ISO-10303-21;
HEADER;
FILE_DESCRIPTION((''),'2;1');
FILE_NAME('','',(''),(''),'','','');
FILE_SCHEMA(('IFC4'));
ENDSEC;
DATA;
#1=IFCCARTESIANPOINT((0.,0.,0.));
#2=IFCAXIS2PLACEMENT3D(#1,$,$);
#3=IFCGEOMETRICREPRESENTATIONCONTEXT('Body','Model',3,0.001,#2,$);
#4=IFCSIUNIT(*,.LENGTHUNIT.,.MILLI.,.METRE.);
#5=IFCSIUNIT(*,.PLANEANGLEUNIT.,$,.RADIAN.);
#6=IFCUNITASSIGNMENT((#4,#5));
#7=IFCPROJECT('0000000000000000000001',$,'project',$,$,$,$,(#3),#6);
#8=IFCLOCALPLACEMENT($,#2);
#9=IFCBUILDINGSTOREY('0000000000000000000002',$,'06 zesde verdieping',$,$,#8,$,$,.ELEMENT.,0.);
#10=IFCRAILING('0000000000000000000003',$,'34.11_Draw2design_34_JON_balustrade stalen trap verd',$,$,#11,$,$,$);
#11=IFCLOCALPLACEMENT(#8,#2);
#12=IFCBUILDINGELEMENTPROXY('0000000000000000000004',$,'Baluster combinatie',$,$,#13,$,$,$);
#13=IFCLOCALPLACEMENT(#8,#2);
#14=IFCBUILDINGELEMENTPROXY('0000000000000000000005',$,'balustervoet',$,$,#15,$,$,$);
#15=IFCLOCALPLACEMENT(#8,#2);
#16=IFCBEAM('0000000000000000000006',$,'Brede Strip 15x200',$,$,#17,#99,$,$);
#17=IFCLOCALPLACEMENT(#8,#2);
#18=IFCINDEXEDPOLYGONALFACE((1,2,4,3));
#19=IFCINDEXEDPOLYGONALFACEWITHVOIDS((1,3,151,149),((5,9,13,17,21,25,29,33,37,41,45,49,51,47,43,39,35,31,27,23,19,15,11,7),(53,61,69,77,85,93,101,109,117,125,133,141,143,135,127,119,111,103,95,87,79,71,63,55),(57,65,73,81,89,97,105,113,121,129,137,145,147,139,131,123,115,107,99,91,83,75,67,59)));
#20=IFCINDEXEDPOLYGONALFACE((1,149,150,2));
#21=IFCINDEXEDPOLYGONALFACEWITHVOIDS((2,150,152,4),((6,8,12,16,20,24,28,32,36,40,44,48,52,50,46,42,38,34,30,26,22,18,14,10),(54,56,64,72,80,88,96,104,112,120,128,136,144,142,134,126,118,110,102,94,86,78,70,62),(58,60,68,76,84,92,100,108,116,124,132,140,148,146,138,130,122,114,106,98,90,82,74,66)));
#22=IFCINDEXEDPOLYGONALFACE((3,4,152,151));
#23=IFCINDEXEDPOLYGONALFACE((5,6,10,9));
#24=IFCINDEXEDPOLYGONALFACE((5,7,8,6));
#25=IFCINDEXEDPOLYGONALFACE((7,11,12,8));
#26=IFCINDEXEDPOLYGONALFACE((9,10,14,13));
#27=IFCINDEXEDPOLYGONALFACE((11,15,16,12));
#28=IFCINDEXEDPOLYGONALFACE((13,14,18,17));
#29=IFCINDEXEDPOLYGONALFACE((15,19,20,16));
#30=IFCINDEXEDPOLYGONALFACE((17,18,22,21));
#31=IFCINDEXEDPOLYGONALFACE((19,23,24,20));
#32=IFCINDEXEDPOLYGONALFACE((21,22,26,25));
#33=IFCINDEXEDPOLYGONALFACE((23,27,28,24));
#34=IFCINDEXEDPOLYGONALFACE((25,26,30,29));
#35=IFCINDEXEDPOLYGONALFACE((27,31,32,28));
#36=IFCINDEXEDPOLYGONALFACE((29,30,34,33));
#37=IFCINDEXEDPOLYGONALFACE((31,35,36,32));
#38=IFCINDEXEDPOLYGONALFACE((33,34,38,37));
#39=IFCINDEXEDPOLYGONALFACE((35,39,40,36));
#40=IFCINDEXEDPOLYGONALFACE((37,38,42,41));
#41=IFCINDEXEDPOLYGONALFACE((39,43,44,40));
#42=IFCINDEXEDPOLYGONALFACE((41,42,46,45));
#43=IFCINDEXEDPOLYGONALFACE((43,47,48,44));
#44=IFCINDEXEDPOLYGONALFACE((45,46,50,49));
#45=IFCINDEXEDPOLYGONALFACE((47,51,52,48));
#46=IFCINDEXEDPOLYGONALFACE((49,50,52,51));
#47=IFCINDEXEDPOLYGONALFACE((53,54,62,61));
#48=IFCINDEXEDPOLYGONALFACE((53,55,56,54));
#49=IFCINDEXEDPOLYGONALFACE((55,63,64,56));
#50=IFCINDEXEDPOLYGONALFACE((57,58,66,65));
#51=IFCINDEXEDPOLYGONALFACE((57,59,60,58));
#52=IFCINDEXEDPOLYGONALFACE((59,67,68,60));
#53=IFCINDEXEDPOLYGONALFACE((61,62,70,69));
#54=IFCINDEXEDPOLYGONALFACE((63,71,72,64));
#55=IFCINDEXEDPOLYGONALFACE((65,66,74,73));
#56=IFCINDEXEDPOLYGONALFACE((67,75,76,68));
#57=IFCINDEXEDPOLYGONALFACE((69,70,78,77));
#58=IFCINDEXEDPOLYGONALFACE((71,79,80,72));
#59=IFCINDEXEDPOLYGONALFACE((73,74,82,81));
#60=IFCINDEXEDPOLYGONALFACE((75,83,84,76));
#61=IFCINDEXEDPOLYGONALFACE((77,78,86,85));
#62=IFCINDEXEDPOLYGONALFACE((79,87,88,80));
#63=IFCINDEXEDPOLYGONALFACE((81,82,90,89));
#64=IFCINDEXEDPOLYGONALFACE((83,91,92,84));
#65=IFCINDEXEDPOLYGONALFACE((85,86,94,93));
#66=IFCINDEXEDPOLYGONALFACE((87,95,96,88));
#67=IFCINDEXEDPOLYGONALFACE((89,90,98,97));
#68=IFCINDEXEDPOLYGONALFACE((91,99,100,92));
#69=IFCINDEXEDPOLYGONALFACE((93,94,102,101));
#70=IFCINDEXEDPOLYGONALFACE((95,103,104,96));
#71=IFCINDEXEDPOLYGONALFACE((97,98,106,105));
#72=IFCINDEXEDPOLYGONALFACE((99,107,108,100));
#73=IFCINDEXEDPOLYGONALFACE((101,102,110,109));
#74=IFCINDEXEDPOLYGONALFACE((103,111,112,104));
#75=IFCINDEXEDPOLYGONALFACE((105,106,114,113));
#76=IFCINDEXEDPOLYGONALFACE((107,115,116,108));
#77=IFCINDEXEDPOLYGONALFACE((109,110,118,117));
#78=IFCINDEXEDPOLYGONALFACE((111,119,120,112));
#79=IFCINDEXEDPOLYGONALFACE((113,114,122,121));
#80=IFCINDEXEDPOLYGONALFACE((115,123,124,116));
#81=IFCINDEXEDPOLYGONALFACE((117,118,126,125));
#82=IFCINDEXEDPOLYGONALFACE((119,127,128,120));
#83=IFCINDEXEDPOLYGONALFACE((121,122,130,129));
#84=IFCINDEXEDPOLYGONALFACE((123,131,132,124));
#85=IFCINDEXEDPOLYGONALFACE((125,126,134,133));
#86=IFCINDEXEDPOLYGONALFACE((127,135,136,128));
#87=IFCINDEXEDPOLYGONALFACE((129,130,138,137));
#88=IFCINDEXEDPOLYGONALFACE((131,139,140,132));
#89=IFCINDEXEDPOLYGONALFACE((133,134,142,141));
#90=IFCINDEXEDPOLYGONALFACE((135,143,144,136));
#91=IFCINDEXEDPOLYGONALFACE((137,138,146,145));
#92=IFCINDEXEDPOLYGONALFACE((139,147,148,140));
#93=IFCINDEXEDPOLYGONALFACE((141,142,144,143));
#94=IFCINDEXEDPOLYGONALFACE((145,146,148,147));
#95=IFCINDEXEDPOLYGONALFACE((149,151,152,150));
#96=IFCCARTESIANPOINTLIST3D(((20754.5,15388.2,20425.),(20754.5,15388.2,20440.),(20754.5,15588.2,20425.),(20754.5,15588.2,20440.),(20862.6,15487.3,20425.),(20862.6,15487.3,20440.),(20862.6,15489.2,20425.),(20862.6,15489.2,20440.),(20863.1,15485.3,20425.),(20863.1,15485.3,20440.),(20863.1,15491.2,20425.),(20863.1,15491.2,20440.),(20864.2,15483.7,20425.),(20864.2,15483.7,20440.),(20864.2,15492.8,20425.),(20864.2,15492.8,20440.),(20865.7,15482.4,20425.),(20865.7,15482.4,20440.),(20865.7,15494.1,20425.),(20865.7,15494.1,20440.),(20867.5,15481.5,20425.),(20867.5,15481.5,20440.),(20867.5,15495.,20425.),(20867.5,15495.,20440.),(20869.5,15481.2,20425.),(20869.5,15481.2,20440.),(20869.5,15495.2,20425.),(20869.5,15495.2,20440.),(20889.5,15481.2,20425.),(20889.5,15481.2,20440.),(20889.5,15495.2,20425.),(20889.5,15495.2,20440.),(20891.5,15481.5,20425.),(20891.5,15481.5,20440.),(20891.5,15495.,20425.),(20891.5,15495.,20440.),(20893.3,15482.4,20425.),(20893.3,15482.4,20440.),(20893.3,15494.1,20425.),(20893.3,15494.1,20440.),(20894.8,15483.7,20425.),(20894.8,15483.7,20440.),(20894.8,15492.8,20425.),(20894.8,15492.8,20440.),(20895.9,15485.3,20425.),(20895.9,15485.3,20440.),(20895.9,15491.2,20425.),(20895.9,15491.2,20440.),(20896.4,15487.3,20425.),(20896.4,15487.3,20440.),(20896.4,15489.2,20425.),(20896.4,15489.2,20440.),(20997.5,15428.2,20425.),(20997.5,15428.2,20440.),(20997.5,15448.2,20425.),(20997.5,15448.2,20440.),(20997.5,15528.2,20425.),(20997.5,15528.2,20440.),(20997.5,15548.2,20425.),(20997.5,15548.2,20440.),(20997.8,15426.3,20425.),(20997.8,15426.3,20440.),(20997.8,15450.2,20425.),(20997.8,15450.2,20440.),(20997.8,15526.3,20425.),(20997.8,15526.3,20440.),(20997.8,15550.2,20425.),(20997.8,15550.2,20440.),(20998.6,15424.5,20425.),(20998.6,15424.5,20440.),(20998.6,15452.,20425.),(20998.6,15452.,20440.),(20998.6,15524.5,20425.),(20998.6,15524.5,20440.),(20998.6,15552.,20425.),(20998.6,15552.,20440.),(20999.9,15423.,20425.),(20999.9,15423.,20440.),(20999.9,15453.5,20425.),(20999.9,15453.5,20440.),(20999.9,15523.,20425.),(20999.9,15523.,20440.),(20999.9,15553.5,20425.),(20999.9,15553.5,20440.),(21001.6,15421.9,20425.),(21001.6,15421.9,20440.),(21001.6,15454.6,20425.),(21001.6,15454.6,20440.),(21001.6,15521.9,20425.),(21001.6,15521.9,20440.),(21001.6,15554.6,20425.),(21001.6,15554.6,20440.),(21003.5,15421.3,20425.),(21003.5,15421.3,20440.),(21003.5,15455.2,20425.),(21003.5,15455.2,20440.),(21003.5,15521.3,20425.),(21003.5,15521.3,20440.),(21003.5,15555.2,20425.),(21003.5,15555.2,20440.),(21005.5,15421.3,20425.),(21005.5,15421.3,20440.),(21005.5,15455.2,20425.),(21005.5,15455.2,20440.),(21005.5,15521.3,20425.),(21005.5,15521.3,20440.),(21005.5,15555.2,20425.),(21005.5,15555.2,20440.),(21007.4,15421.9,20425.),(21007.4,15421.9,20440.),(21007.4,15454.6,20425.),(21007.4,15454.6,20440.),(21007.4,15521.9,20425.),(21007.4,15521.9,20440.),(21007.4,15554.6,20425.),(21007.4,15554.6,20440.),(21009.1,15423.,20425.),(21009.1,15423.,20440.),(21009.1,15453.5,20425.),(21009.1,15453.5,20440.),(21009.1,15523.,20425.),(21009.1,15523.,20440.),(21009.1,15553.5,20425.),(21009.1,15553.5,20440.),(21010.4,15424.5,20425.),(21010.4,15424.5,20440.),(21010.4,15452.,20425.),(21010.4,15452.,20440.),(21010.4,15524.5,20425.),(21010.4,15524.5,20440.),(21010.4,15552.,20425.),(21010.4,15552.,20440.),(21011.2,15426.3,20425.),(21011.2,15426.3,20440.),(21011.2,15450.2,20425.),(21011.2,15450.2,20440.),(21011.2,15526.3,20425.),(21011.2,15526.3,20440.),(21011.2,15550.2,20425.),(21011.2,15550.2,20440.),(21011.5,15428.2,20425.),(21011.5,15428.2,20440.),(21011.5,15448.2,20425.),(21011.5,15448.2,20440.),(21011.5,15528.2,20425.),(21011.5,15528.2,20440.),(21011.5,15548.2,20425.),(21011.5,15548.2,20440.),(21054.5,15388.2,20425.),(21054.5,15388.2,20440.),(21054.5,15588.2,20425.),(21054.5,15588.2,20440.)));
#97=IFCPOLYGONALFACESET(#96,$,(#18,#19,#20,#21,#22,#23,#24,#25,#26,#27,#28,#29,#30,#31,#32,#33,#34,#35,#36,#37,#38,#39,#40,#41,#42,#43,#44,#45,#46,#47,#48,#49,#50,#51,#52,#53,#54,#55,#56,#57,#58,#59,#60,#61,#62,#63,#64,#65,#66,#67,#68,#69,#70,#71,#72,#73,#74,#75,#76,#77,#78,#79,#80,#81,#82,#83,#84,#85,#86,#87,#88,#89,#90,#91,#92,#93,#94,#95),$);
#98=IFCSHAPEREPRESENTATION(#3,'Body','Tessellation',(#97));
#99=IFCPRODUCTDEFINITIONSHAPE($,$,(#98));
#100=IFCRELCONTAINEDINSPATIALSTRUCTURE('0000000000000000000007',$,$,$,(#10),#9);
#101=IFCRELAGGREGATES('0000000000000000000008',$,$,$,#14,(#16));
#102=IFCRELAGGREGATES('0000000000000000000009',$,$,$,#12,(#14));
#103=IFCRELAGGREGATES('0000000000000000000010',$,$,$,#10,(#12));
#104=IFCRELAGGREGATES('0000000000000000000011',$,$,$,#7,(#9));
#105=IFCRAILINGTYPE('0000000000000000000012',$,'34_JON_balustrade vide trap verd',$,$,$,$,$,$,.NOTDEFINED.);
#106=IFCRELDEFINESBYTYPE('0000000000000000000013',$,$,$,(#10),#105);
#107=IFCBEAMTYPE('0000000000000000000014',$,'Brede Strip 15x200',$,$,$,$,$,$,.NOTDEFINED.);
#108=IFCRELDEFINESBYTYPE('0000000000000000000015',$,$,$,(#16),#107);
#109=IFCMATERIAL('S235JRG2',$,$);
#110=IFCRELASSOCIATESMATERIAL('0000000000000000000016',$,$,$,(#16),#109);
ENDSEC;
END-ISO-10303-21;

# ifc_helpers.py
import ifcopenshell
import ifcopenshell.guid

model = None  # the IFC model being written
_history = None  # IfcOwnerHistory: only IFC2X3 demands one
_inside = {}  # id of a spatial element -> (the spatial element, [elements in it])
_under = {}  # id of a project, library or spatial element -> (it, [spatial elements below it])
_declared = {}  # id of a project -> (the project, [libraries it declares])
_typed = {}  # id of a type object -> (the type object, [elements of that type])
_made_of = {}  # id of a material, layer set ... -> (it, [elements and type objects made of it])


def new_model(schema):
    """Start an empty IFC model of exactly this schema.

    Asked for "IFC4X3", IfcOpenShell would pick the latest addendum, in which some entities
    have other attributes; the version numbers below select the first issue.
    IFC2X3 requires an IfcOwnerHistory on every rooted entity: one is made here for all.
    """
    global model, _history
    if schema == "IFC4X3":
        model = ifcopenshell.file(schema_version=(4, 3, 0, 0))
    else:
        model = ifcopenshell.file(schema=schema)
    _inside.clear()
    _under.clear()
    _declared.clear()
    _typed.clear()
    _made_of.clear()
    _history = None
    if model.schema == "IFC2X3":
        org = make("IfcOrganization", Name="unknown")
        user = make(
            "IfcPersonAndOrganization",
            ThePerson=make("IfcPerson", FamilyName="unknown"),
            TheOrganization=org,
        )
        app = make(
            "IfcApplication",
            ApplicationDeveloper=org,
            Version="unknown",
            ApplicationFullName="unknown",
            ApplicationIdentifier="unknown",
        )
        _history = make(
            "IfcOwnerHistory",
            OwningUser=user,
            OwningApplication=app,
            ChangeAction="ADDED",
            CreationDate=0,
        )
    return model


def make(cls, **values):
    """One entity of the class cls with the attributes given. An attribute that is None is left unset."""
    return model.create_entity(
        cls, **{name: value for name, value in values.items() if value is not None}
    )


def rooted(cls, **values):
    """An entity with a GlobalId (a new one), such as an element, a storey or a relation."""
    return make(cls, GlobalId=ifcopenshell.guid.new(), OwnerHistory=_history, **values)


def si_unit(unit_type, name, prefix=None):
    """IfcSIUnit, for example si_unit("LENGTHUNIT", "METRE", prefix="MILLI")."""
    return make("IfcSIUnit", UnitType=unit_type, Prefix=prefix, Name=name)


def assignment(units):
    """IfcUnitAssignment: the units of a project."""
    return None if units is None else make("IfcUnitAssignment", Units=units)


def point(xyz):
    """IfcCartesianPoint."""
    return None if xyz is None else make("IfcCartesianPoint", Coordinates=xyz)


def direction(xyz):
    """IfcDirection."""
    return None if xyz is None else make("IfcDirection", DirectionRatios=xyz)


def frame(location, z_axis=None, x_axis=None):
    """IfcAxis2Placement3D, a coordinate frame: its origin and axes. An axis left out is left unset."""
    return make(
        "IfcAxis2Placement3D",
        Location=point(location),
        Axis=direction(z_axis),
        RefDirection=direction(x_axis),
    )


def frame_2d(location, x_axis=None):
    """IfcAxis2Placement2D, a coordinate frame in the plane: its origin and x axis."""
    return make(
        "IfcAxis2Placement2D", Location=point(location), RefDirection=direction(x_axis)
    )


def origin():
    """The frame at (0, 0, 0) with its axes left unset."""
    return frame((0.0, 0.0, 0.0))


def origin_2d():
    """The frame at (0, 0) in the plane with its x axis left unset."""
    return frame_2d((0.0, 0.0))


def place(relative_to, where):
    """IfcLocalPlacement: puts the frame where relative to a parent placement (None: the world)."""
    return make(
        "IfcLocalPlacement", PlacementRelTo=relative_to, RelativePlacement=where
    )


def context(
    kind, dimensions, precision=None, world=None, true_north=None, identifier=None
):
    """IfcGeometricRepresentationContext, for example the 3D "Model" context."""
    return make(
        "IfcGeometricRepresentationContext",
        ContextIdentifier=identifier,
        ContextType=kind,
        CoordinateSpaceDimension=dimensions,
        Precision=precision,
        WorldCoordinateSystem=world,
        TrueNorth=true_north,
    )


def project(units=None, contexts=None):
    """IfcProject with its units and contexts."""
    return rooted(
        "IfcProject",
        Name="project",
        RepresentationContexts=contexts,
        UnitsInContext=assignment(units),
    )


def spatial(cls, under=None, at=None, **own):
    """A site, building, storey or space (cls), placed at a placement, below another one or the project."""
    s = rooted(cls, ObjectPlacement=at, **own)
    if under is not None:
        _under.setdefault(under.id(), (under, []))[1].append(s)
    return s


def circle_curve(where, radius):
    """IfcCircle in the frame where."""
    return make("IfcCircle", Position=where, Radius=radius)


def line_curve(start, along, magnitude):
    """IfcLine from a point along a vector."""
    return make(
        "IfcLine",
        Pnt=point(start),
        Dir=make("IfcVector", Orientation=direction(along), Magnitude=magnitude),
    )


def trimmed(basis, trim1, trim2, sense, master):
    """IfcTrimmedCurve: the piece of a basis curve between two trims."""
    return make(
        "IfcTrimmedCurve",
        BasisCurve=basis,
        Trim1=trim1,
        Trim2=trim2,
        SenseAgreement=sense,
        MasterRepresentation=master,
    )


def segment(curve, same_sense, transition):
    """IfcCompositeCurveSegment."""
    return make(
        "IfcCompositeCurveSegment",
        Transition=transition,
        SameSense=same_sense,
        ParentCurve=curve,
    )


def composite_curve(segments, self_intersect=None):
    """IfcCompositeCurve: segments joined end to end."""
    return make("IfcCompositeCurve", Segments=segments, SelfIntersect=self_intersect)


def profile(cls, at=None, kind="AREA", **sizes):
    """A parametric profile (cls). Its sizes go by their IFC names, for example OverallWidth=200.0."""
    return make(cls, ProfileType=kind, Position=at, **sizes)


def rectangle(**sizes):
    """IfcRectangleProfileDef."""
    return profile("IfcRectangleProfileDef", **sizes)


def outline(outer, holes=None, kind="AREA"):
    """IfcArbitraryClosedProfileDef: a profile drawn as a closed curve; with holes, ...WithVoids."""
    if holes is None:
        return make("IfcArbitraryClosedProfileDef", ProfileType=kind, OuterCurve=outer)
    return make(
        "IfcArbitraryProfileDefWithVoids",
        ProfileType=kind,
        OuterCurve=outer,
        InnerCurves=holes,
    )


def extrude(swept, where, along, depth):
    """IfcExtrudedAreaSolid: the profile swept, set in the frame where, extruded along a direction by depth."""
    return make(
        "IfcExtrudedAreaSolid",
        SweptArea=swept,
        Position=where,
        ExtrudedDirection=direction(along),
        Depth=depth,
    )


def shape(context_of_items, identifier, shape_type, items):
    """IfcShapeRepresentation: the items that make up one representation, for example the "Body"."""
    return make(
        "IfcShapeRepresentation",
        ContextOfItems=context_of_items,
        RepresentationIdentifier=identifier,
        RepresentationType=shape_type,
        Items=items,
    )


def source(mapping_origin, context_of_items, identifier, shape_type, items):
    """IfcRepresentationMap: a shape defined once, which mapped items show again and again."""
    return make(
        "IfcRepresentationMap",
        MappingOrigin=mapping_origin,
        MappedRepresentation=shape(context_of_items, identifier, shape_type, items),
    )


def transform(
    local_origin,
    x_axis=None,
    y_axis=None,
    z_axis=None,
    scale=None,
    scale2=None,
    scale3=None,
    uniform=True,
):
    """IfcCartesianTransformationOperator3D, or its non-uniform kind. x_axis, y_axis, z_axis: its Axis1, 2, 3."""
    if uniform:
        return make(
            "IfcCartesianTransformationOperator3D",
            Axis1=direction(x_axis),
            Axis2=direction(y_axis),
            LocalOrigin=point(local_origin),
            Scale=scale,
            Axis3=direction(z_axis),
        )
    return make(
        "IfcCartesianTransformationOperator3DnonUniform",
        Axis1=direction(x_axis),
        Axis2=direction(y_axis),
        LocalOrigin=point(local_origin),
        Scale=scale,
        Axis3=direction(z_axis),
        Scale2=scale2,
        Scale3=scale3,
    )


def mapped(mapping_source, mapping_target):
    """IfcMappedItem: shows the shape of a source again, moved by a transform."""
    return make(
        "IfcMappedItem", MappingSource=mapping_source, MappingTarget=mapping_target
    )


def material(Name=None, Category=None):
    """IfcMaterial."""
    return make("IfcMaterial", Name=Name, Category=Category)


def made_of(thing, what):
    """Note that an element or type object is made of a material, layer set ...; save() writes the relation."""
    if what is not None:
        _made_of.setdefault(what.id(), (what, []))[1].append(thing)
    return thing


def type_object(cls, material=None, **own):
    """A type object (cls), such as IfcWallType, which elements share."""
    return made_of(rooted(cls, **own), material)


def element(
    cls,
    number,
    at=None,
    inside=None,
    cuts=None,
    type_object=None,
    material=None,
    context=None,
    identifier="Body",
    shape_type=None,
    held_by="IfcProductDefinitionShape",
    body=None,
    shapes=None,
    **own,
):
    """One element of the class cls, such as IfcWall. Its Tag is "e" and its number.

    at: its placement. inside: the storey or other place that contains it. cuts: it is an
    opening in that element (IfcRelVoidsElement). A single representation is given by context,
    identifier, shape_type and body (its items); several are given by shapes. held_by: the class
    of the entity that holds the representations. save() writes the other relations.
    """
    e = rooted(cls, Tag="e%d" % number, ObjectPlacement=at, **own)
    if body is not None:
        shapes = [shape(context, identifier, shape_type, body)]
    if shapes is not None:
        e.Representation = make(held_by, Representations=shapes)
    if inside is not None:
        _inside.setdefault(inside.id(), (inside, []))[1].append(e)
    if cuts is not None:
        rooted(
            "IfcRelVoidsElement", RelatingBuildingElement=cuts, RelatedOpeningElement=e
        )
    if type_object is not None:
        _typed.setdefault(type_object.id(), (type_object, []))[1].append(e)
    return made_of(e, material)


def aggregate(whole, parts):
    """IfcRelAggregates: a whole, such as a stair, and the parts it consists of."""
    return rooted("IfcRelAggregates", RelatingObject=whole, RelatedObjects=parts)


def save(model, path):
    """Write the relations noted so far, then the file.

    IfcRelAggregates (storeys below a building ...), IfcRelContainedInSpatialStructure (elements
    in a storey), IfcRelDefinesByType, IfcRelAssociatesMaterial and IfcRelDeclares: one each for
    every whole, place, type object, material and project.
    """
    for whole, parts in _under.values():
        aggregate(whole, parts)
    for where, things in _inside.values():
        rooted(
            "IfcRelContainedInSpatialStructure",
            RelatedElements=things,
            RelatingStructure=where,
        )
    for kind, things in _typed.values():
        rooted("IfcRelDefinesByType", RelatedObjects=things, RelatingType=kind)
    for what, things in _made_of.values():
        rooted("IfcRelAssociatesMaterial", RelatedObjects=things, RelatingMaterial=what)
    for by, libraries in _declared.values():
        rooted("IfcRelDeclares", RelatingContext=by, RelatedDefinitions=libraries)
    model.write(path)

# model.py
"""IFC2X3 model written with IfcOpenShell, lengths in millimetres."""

from ifc_helpers import new_model, si_unit, point, frame, frame_2d, origin, origin_2d, place, context, project, spatial, circle_curve, line_curve, trimmed, segment, composite_curve, rectangle, outline, extrude, source, transform, mapped, material, type_object, element, aggregate, save


model = new_model("IFC2X3")

# Units and contexts
model_context = context("Model", 3, precision=0.001, world=origin(), identifier="Body")
ifc_project = project(units=[si_unit("LENGTHUNIT", "METRE", prefix="MILLI"), si_unit("PLANEANGLEUNIT", "RADIAN")], contexts=[model_context])

# Storey
storey_placement = place(None, origin())
storey = spatial("IfcBuildingStorey", under=ifc_project, at=storey_placement, Name="06 zesde verdieping", CompositionType="ELEMENT", Elevation=0.0)

# Railing, building element proxies, beam, openings
railing_type = type_object("IfcRailingType", Name="34_JON_balustrade vide trap verd")
railing_placement = place(storey_placement, frame((-1939.6, -29817.1, 74783.6)))
railing = element("IfcRailing", 1, at=railing_placement, inside=storey, type_object=railing_type, Name="34.11_Draw2design_34_JON_balustrade stalen trap verd")
proxy_1_placement = place(railing_placement, frame((22994.2, 44650.4, -54348.6), z_axis=(0.0, 0.0, 1.0), x_axis=(0.0, 1.0, 0.0)))
proxy_1 = element("IfcBuildingElementProxy", 2, at=proxy_1_placement, Name="Baluster combinatie")
proxy_2_placement = place(proxy_1_placement, frame((-44257.5, 21054.5, -49235.0), z_axis=(0.0, 0.0, 1.0), x_axis=(0.0, -1.0, 0.0)))
proxy_2 = element("IfcBuildingElementProxy", 3, at=proxy_2_placement, Name="balustervoet")
ifc_material_1 = material(Name="S235JRG2")
beam_type_1 = type_object("IfcBeamType", Name="Brede Strip 15x200")
shared_shape_1 = source(origin(), model_context, "Body", "SweptSolid", [
    extrude(rectangle(XDim=15.0, YDim=200.0, at=origin_2d()), origin(), (0.0, 0.0, -1.0), 300.0),
])
beam_1_placement = place(proxy_2_placement, frame((21054.5, 44912.5, 49232.5), z_axis=(1.0, 0.0, 0.0), x_axis=(0.0, 0.0, 1.0)))
beam_1 = element("IfcBeam", 4, at=beam_1_placement, type_object=beam_type_1, material=ifc_material_1, Name="Brede Strip 15x200", context=model_context, shape_type="MappedRepresentation", body=[
    mapped(shared_shape_1, transform((0.0, 0.0, 0.0), scale=1.0)),
])
opening_1_placement = place(beam_1_placement, frame((7.5, 0.0, -175.0), z_axis=(-1.0, 0.0, 0.0), x_axis=(0.0, 0.0, -1.0)))
element("IfcOpeningElement", 5, at=opening_1_placement, cuts=beam_1, ObjectType="Opening", context=model_context, shape_type="SweptSolid", body=[
    extrude(outline(composite_curve([segment(trimmed(circle_curve(frame_2d((10.0, 0.0), x_axis=(0.0, -1.0)), 7.0), [point((10.0, 7.0))], [point((10.0, -7.0))], False, "CARTESIAN"), True, "CONTINUOUS"), segment(trimmed(line_curve((10.0, -7.0), (-20.0, 0.0), 20.0), [point((10.0, -7.0))], [point((-10.0, -7.0))], True, "CARTESIAN"), True, "CONTINUOUS"), segment(trimmed(circle_curve(frame_2d((-10.0, 0.0), x_axis=(0.0, -1.0)), 7.0), [point((-10.0, -7.0))], [point((-10.0, 7.0))], False, "CARTESIAN"), True, "CONTINUOUS"), segment(trimmed(line_curve((-10.0, 7.0), (20.0, 0.0), 20.0), [point((-10.0, 7.0))], [point((10.0, 7.0))], True, "CARTESIAN"), True, "CONTINUOUS")], self_intersect=False)), origin(), (0.0, 0.0, 1.0), 15.0),
])
opening_2_placement = place(beam_1_placement, frame((7.5, -50.0, -50.0), z_axis=(-1.0, 0.0, 0.0), x_axis=(0.0, -1.0, 0.0)))
element("IfcOpeningElement", 6, at=opening_2_placement, cuts=beam_1, ObjectType="Opening", context=model_context, shape_type="SweptSolid", body=[
    extrude(outline(composite_curve([segment(trimmed(circle_curve(frame_2d((10.0, 0.0), x_axis=(0.0, -1.0)), 7.0), [point((10.0, 7.0))], [point((10.0, -7.0))], False, "CARTESIAN"), True, "CONTINUOUS"), segment(trimmed(line_curve((10.0, -7.0), (-20.0, 0.0), 20.0), [point((10.0, -7.0))], [point((-10.0, -7.0))], True, "CARTESIAN"), True, "CONTINUOUS"), segment(trimmed(circle_curve(frame_2d((-10.0, 0.0), x_axis=(0.0, -1.0)), 7.0), [point((-10.0, -7.0))], [point((-10.0, 7.0))], False, "CARTESIAN"), True, "CONTINUOUS"), segment(trimmed(line_curve((-10.0, 7.0), (20.0, 0.0), 20.0), [point((-10.0, 7.0))], [point((10.0, 7.0))], True, "CARTESIAN"), True, "CONTINUOUS")], self_intersect=False)), origin(), (0.0, 0.0, 1.0), 15.0),
])
opening_3_placement = place(beam_1_placement, frame((7.5, 50.0, -50.0), z_axis=(-1.0, 0.0, 0.0), x_axis=(0.0, -1.0, 0.0)))
element("IfcOpeningElement", 7, at=opening_3_placement, cuts=beam_1, ObjectType="Opening", context=model_context, shape_type="SweptSolid", body=[
    extrude(outline(composite_curve([segment(trimmed(circle_curve(frame_2d((10.0, 0.0), x_axis=(0.0, -1.0)), 7.0), [point((10.0, 7.0))], [point((10.0, -7.0))], False, "CARTESIAN"), True, "CONTINUOUS"), segment(trimmed(line_curve((10.0, -7.0), (-20.0, 0.0), 20.0), [point((10.0, -7.0))], [point((-10.0, -7.0))], True, "CARTESIAN"), True, "CONTINUOUS"), segment(trimmed(circle_curve(frame_2d((-10.0, 0.0), x_axis=(0.0, -1.0)), 7.0), [point((-10.0, -7.0))], [point((-10.0, 7.0))], False, "CARTESIAN"), True, "CONTINUOUS"), segment(trimmed(line_curve((-10.0, 7.0), (20.0, 0.0), 20.0), [point((-10.0, 7.0))], [point((10.0, 7.0))], True, "CARTESIAN"), True, "CONTINUOUS")], self_intersect=False)), origin(), (0.0, 0.0, 1.0), 15.0),
])
aggregate(proxy_2, [beam_1])
aggregate(proxy_1, [proxy_2])
aggregate(railing, [proxy_1])

save(model, "model.ifc")
